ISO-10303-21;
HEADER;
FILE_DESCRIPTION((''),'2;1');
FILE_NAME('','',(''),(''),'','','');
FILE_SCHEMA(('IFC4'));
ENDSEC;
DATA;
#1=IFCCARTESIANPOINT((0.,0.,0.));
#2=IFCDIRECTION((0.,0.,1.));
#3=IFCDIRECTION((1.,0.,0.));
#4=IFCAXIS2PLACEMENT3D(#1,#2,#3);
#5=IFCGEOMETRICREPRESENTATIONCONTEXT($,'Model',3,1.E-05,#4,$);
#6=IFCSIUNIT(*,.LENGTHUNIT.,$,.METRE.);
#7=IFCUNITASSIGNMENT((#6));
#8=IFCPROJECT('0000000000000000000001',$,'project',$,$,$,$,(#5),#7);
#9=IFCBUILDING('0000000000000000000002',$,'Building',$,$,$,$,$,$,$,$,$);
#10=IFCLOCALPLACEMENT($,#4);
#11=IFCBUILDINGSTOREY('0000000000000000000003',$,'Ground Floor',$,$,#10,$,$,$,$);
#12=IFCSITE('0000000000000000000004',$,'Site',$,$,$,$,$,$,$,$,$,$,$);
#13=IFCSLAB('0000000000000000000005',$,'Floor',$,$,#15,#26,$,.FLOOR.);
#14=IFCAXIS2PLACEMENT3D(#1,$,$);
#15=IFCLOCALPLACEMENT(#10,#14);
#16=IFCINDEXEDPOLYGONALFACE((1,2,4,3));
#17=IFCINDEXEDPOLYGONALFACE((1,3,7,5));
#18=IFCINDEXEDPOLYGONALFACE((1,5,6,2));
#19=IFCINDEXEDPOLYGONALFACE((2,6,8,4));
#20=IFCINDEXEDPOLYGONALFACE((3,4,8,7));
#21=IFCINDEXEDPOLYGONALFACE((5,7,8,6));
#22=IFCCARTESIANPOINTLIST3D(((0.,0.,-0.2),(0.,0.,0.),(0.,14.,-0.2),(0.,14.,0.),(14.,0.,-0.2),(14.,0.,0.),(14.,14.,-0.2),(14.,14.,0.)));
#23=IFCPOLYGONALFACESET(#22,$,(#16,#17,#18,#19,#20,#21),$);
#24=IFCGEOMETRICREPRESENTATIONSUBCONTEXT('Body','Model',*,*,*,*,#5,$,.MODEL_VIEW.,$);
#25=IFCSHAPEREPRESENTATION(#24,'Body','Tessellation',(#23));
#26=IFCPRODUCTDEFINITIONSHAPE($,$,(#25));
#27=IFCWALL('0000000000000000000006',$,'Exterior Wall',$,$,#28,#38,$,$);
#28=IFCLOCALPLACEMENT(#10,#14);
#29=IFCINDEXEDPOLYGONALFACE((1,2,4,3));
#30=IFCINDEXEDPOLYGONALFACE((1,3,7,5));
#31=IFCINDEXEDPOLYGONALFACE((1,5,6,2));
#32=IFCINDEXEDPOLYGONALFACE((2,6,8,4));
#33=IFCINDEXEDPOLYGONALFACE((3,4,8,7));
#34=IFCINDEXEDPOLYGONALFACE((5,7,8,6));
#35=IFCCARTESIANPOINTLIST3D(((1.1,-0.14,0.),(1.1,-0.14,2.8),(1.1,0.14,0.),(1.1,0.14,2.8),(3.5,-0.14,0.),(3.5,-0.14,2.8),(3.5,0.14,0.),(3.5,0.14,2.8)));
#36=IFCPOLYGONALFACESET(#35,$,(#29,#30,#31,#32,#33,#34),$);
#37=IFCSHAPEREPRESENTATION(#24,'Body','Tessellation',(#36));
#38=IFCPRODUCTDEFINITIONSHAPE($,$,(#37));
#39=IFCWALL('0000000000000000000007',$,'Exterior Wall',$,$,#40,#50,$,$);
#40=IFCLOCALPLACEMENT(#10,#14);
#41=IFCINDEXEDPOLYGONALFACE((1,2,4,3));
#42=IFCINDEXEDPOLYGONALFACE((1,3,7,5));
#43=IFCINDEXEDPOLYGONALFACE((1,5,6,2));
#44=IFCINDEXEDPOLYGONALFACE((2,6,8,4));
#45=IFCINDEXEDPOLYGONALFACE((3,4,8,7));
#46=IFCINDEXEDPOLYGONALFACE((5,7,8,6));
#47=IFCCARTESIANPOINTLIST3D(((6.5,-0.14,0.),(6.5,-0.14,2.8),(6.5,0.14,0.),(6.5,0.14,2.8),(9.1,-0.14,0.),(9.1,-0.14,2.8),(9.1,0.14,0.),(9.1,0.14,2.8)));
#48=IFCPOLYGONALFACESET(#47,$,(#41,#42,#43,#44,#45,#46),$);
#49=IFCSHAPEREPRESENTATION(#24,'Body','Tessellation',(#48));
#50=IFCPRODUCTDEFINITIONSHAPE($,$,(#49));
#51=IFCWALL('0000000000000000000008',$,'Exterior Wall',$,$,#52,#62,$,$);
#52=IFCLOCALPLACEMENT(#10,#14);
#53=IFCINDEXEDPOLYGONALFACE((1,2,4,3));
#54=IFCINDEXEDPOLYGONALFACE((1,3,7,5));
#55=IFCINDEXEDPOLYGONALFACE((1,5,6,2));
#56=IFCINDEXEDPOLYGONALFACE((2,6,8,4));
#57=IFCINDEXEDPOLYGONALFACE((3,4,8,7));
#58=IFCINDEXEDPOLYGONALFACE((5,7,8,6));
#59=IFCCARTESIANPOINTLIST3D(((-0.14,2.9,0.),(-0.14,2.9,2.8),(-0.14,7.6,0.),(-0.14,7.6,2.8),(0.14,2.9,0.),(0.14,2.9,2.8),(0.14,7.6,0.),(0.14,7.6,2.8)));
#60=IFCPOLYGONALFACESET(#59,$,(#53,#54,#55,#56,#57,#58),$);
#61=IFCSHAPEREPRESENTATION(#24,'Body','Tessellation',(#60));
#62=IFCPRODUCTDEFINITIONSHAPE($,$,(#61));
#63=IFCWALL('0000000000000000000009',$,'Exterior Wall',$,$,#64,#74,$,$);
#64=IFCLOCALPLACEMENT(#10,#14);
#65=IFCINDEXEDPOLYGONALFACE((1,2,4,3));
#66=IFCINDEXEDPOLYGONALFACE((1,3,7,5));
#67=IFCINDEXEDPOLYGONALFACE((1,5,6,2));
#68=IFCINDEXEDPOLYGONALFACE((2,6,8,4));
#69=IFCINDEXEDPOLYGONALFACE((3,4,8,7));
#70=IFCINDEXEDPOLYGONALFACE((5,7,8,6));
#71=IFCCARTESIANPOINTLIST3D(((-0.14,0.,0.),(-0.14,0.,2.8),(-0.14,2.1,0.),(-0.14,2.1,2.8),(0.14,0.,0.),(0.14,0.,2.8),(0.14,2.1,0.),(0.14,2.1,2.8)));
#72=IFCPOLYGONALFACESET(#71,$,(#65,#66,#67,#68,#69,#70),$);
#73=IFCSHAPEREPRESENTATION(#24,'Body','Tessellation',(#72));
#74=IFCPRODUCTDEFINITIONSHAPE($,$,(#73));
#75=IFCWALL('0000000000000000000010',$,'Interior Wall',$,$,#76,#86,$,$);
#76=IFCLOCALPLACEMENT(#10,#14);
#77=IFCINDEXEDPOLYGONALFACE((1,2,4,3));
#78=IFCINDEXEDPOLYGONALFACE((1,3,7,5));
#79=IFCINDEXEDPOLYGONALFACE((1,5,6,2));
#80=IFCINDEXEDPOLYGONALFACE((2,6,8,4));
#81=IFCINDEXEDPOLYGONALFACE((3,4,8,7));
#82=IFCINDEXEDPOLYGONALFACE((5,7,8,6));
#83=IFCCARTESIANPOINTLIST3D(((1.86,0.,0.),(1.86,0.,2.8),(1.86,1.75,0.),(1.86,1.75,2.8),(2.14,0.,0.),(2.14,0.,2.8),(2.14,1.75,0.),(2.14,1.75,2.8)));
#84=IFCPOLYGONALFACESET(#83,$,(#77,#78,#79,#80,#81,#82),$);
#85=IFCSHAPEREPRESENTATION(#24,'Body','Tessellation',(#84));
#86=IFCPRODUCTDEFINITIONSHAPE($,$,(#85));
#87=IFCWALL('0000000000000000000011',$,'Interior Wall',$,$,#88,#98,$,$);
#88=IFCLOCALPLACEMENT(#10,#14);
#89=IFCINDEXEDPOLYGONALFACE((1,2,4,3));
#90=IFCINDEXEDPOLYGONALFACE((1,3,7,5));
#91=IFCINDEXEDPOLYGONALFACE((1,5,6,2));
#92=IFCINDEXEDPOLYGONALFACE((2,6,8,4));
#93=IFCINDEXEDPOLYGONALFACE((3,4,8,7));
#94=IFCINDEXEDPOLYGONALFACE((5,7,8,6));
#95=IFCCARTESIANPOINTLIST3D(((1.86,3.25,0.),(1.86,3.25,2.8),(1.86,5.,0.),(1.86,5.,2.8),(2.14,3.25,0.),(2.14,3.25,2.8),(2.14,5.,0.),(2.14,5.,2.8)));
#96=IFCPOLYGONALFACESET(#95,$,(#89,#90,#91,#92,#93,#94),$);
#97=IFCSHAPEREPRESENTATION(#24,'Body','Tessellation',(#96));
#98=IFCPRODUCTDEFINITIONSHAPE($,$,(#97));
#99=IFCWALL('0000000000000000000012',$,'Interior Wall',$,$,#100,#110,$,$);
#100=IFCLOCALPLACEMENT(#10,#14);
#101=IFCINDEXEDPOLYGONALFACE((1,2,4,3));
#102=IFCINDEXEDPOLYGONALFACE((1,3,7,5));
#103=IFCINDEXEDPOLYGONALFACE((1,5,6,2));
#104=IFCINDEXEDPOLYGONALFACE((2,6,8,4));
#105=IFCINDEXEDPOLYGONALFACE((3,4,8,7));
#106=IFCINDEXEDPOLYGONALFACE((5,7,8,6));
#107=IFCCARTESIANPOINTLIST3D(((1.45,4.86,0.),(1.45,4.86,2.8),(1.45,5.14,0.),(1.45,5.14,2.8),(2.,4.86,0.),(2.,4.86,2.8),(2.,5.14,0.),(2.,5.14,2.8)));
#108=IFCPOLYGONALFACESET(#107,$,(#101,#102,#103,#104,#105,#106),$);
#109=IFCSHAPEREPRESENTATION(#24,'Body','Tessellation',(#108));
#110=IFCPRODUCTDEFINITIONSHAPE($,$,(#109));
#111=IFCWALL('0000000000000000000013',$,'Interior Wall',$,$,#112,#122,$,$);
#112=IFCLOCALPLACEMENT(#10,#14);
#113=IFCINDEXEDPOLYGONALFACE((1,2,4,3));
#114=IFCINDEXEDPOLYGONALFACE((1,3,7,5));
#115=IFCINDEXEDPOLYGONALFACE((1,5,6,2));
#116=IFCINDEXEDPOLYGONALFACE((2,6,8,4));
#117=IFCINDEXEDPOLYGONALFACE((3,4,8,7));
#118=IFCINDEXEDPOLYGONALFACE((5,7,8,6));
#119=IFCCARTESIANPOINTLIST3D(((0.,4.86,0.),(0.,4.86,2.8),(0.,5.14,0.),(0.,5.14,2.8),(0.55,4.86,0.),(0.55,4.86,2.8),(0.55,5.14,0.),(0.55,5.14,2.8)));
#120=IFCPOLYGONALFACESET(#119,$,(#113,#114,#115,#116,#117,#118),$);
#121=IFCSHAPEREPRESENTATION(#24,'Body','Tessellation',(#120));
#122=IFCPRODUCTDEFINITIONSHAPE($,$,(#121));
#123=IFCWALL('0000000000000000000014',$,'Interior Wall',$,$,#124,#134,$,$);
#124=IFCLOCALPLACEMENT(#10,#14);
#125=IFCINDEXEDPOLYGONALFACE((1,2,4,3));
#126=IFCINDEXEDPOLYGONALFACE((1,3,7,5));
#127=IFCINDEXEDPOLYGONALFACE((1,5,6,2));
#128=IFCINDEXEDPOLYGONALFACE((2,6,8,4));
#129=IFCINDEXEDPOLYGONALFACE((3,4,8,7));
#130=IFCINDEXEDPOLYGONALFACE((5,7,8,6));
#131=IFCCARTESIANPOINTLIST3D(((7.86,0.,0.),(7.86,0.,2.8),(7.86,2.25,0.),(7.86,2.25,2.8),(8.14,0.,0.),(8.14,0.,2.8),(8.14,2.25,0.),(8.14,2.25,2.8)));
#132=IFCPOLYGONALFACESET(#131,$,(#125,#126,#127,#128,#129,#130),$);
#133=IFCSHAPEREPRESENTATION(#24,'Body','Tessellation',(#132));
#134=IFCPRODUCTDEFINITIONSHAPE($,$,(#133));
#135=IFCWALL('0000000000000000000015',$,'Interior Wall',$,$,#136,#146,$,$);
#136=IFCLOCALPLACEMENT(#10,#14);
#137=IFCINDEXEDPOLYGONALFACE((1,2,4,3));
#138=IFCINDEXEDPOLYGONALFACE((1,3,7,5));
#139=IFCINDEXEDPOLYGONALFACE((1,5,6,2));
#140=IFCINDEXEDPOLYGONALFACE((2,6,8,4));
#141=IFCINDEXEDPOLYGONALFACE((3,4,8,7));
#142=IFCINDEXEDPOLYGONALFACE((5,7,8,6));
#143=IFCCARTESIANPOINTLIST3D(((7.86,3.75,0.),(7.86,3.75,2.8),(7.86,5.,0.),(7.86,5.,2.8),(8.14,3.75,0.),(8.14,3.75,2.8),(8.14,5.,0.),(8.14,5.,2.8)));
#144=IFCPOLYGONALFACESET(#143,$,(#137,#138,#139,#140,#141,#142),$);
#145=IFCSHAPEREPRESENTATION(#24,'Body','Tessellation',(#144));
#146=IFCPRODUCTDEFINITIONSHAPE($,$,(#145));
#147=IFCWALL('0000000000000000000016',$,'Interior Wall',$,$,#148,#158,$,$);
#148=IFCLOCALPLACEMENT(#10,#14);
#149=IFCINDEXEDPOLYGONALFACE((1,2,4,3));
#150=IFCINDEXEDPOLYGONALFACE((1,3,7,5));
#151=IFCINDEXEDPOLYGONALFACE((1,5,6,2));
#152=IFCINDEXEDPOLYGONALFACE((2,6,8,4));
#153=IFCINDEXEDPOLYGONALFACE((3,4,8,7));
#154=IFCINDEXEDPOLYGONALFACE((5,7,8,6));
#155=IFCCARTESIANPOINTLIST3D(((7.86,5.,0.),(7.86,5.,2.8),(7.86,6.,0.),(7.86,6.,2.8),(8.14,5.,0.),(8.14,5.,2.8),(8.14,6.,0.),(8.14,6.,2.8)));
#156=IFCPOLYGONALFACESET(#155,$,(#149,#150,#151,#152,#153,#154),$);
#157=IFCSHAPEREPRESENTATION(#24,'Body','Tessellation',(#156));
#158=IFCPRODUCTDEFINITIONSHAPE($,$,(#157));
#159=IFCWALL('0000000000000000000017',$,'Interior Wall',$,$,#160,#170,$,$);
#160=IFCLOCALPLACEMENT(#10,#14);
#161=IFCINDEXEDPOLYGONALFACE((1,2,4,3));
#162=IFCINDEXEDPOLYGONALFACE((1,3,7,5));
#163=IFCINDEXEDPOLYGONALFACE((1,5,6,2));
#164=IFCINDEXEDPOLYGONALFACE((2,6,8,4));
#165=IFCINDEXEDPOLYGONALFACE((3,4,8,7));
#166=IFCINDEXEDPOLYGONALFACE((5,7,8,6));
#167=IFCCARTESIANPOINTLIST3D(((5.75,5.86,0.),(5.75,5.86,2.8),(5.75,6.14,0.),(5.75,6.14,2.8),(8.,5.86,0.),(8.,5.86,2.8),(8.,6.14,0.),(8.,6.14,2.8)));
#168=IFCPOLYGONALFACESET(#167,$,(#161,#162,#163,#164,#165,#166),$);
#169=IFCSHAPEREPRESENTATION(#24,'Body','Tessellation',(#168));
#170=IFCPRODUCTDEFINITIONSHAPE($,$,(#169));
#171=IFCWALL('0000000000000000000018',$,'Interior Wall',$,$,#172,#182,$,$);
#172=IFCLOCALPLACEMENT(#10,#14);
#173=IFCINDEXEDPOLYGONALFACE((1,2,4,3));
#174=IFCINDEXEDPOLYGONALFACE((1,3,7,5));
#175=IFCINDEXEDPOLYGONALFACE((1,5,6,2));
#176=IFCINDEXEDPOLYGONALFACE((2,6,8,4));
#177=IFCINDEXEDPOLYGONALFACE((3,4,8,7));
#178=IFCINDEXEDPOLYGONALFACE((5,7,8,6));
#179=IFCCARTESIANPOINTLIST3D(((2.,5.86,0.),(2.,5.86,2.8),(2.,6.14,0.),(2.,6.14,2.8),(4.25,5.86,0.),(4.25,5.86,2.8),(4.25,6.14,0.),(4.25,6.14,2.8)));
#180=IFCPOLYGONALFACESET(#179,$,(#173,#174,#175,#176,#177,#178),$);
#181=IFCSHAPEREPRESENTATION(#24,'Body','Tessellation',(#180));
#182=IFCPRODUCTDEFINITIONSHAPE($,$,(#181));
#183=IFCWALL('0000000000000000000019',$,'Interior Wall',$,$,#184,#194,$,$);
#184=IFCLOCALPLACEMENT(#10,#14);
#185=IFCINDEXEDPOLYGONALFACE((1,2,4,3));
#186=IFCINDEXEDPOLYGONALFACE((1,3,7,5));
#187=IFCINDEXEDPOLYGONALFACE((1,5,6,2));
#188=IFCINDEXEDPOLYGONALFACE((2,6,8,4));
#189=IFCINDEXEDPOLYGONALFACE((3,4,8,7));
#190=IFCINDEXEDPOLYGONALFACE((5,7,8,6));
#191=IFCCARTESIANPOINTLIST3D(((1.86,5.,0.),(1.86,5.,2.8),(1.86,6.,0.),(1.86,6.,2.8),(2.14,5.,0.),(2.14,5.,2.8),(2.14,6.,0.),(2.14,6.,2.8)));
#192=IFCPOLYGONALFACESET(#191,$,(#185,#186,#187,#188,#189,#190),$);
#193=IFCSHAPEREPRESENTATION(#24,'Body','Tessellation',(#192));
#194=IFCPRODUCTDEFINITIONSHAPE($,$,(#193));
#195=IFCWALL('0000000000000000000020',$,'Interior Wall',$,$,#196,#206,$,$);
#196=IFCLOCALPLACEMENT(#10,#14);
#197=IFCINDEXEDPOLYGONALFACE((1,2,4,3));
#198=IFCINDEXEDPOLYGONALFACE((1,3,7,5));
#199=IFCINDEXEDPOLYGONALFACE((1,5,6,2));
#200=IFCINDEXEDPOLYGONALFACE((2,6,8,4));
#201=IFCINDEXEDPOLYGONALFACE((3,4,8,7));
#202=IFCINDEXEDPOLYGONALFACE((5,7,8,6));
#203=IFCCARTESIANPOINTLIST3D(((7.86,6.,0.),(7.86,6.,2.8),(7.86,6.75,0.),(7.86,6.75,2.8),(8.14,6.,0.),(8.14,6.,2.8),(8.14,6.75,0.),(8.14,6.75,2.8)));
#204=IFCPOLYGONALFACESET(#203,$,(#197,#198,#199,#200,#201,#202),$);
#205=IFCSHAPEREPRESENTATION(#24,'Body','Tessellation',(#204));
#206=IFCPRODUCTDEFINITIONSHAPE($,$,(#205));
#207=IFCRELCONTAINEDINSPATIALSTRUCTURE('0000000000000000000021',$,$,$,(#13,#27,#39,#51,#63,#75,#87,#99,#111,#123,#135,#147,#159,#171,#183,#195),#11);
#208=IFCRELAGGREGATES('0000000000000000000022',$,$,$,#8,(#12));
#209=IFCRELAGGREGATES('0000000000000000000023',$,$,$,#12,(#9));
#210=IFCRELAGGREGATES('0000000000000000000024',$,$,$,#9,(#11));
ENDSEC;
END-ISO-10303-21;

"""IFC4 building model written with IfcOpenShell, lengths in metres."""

from ifc_helpers import new_model, si_unit, frame, origin_with_axes, place, context, subcontext, project, spatial, indexed_curve, outline, extrude, element, save


model = new_model("IFC4")

# Units and contexts
model_context = context("Model", 3, precision=1e-05, world=origin_with_axes())
body_context = subcontext(model_context, "Body", "Model", "MODEL_VIEW")
ifc_project = project(units=[si_unit("LENGTHUNIT", "METRE")], contexts=[model_context])

# Site, building, storey
site = spatial("IfcSite", under=ifc_project, Name="Site")
building = spatial("IfcBuilding", under=site, Name="Building")
storey_placement = place(None, origin_with_axes())
storey = spatial("IfcBuildingStorey", under=building, at=storey_placement, Name="Ground Floor")

# Slab
slab_placement = place(storey_placement, frame((0.0, 0.0, -0.2), z_axis=(0.0, 0.0, 1.0), x_axis=(1.0, 0.0, 0.0)))
element("IfcSlab", 1, at=slab_placement, inside=storey, Name="Floor", PredefinedType="FLOOR", context=body_context, shape_type="SweptSolid", body=[
    extrude(outline(indexed_curve([(0.0, 0.0), (14.0, 0.0), (14.0, 14.0), (0.0, 14.0)])), None, (0.0, 0.0, 1.0), 0.2),
])

# Walls
wall_1_placement = place(storey_placement, frame((1.1, 0.0, 0.0), z_axis=(0.0, 0.0, 1.0), x_axis=(1.0, 0.0, 0.0)))
element("IfcWall", 2, at=wall_1_placement, inside=storey, Name="Exterior Wall", context=body_context, shape_type="SweptSolid", body=[
    extrude(outline(indexed_curve([(0.0, 0.0), (0.0, 0.28), (2.4, 0.28), (2.4, 0.0), (0.0, 0.0)], self_intersect=False)), frame((0.0, -0.14, 0.0), z_axis=(0.0, 0.0, 1.0), x_axis=(1.0, 0.0, 0.0)), (0.0, 0.0, 1.0), 2.8),
])
wall_2_placement = place(storey_placement, frame((6.5, 0.0, 0.0), z_axis=(0.0, 0.0, 1.0), x_axis=(1.0, 0.0, 0.0)))
element("IfcWall", 3, at=wall_2_placement, inside=storey, Name="Exterior Wall", context=body_context, shape_type="SweptSolid", body=[
    extrude(outline(indexed_curve([(0.0, 0.0), (0.0, 0.28), (2.6, 0.28), (2.6, 0.0), (0.0, 0.0)], self_intersect=False)), frame((0.0, -0.14, 0.0), z_axis=(0.0, 0.0, 1.0), x_axis=(1.0, 0.0, 0.0)), (0.0, 0.0, 1.0), 2.8),
])
wall_3_placement = place(storey_placement, frame((0.0, 7.6, 0.0), z_axis=(0.0, 0.0, 1.0), x_axis=(0.0, -1.0, 0.0)))
element("IfcWall", 4, at=wall_3_placement, inside=storey, Name="Exterior Wall", context=body_context, shape_type="SweptSolid", body=[
    extrude(outline(indexed_curve([(0.0, 0.0), (0.0, 0.28), (4.7, 0.28), (4.7, 0.0), (0.0, 0.0)], self_intersect=False)), frame((0.0, -0.14, 0.0), z_axis=(0.0, 0.0, 1.0), x_axis=(1.0, 0.0, 0.0)), (0.0, 0.0, 1.0), 2.8),
])
wall_4_placement = place(storey_placement, frame((0.0, 2.1, 0.0), z_axis=(0.0, 0.0, 1.0), x_axis=(0.0, -1.0, 0.0)))
element("IfcWall", 5, at=wall_4_placement, inside=storey, Name="Exterior Wall", context=body_context, shape_type="SweptSolid", body=[
    extrude(outline(indexed_curve([(0.0, 0.0), (0.0, 0.28), (2.1, 0.28), (2.1, 0.0), (0.0, 0.0)], self_intersect=False)), frame((0.0, -0.14, 0.0), z_axis=(0.0, 0.0, 1.0), x_axis=(1.0, 0.0, 0.0)), (0.0, 0.0, 1.0), 2.8),
])
for number, where, z_axis, x_axis, name in (
    (6, (2.0, 0.0, 0.0), (0.0, 0.0, 1.0), (0.0, 1.0, 0.0), "Interior Wall"),
    (7, (2.0, 3.25, 0.0), (0.0, 0.0, 1.0), (0.0, 1.0, 0.0), "Interior Wall"),
):
    element("IfcWall", number, at=place(storey_placement, frame(where, z_axis=z_axis, x_axis=x_axis)), inside=storey, Name=name, context=body_context, shape_type="SweptSolid", body=[
        extrude(outline(indexed_curve([(0.0, 0.0), (0.0, 0.28), (1.75, 0.28), (1.75, 0.0), (0.0, 0.0)], self_intersect=False)), frame((0.0, -0.14, 0.0), z_axis=(0.0, 0.0, 1.0), x_axis=(1.0, 0.0, 0.0)), (0.0, 0.0, 1.0), 2.8),
    ])
for number, where, z_axis, x_axis, name in (
    (8, (2.0, 5.0, 0.0), (0.0, 0.0, 1.0), (-1.0, 0.0, 0.0), "Interior Wall"),
    (9, (0.55, 5.0, 0.0), (0.0, 0.0, 1.0), (-1.0, 0.0, 0.0), "Interior Wall"),
):
    element("IfcWall", number, at=place(storey_placement, frame(where, z_axis=z_axis, x_axis=x_axis)), inside=storey, Name=name, context=body_context, shape_type="SweptSolid", body=[
        extrude(outline(indexed_curve([(0.0, 0.0), (0.0, 0.28), (0.55, 0.28), (0.55, 0.0), (0.0, 0.0)], self_intersect=False)), frame((0.0, -0.14, 0.0), z_axis=(0.0, 0.0, 1.0), x_axis=(1.0, 0.0, 0.0)), (0.0, 0.0, 1.0), 2.8),
    ])
wall_5_placement = place(storey_placement, frame((8.0, 0.0, 0.0), z_axis=(0.0, 0.0, 1.0), x_axis=(0.0, 1.0, 0.0)))
element("IfcWall", 10, at=wall_5_placement, inside=storey, Name="Interior Wall", context=body_context, shape_type="SweptSolid", body=[
    extrude(outline(indexed_curve([(0.0, 0.0), (0.0, 0.28), (2.25, 0.28), (2.25, 0.0), (0.0, 0.0)], self_intersect=False)), frame((0.0, -0.14, 0.0), z_axis=(0.0, 0.0, 1.0), x_axis=(1.0, 0.0, 0.0)), (0.0, 0.0, 1.0), 2.8),
])
wall_6_placement = place(storey_placement, frame((8.0, 3.75, 0.0), z_axis=(0.0, 0.0, 1.0), x_axis=(0.0, 1.0, 0.0)))
element("IfcWall", 11, at=wall_6_placement, inside=storey, Name="Interior Wall", context=body_context, shape_type="SweptSolid", body=[
    extrude(outline(indexed_curve([(0.0, 0.0), (0.0, 0.28), (1.25, 0.28), (1.25, 0.0), (0.0, 0.0)], self_intersect=False)), frame((0.0, -0.14, 0.0), z_axis=(0.0, 0.0, 1.0), x_axis=(1.0, 0.0, 0.0)), (0.0, 0.0, 1.0), 2.8),
])
wall_7_placement = place(storey_placement, frame((8.0, 5.0, 0.0), z_axis=(0.0, 0.0, 1.0), x_axis=(0.0, 1.0, 0.0)))
element("IfcWall", 12, at=wall_7_placement, inside=storey, Name="Interior Wall", context=body_context, shape_type="SweptSolid", body=[
    extrude(outline(indexed_curve([(0.0, 0.0), (0.0, 0.28), (1.0, 0.28), (1.0, 0.0), (0.0, 0.0)], self_intersect=False)), frame((0.0, -0.14, 0.0), z_axis=(0.0, 0.0, 1.0), x_axis=(1.0, 0.0, 0.0)), (0.0, 0.0, 1.0), 2.8),
])
for number, where, z_axis, x_axis, name in (
    (13, (8.0, 6.0, 0.0), (0.0, 0.0, 1.0), (-1.0, 0.0, 0.0), "Interior Wall"),
    (14, (4.25, 6.0, 0.0), (0.0, 0.0, 1.0), (-1.0, 0.0, 0.0), "Interior Wall"),
):
    element("IfcWall", number, at=place(storey_placement, frame(where, z_axis=z_axis, x_axis=x_axis)), inside=storey, Name=name, context=body_context, shape_type="SweptSolid", body=[
        extrude(outline(indexed_curve([(0.0, 0.0), (0.0, 0.28), (2.25, 0.28), (2.25, 0.0), (0.0, 0.0)], self_intersect=False)), frame((0.0, -0.14, 0.0), z_axis=(0.0, 0.0, 1.0), x_axis=(1.0, 0.0, 0.0)), (0.0, 0.0, 1.0), 2.8),
    ])
wall_8_placement = place(storey_placement, frame((2.0, 6.0, 0.0), z_axis=(0.0, 0.0, 1.0), x_axis=(0.0, -1.0, 0.0)))
element("IfcWall", 15, at=wall_8_placement, inside=storey, Name="Interior Wall", context=body_context, shape_type="SweptSolid", body=[
    extrude(outline(indexed_curve([(0.0, 0.0), (0.0, 0.28), (1.0, 0.28), (1.0, 0.0), (0.0, 0.0)], self_intersect=False)), frame((0.0, -0.14, 0.0), z_axis=(0.0, 0.0, 1.0), x_axis=(1.0, 0.0, 0.0)), (0.0, 0.0, 1.0), 2.8),
])
wall_9_placement = place(storey_placement, frame((8.0, 6.75, 0.0), z_axis=(0.0, 0.0, 1.0), x_axis=(0.0, -1.0, 0.0)))
element("IfcWall", 16, at=wall_9_placement, inside=storey, Name="Interior Wall", context=body_context, shape_type="SweptSolid", body=[
    extrude(outline(indexed_curve([(0.0, 0.0), (0.0, 0.28), (0.75, 0.28), (0.75, 0.0), (0.0, 0.0)], self_intersect=False)), frame((0.0, -0.14, 0.0), z_axis=(0.0, 0.0, 1.0), x_axis=(1.0, 0.0, 0.0)), (0.0, 0.0, 1.0), 2.8),
])

save(model, "model.ifc")
